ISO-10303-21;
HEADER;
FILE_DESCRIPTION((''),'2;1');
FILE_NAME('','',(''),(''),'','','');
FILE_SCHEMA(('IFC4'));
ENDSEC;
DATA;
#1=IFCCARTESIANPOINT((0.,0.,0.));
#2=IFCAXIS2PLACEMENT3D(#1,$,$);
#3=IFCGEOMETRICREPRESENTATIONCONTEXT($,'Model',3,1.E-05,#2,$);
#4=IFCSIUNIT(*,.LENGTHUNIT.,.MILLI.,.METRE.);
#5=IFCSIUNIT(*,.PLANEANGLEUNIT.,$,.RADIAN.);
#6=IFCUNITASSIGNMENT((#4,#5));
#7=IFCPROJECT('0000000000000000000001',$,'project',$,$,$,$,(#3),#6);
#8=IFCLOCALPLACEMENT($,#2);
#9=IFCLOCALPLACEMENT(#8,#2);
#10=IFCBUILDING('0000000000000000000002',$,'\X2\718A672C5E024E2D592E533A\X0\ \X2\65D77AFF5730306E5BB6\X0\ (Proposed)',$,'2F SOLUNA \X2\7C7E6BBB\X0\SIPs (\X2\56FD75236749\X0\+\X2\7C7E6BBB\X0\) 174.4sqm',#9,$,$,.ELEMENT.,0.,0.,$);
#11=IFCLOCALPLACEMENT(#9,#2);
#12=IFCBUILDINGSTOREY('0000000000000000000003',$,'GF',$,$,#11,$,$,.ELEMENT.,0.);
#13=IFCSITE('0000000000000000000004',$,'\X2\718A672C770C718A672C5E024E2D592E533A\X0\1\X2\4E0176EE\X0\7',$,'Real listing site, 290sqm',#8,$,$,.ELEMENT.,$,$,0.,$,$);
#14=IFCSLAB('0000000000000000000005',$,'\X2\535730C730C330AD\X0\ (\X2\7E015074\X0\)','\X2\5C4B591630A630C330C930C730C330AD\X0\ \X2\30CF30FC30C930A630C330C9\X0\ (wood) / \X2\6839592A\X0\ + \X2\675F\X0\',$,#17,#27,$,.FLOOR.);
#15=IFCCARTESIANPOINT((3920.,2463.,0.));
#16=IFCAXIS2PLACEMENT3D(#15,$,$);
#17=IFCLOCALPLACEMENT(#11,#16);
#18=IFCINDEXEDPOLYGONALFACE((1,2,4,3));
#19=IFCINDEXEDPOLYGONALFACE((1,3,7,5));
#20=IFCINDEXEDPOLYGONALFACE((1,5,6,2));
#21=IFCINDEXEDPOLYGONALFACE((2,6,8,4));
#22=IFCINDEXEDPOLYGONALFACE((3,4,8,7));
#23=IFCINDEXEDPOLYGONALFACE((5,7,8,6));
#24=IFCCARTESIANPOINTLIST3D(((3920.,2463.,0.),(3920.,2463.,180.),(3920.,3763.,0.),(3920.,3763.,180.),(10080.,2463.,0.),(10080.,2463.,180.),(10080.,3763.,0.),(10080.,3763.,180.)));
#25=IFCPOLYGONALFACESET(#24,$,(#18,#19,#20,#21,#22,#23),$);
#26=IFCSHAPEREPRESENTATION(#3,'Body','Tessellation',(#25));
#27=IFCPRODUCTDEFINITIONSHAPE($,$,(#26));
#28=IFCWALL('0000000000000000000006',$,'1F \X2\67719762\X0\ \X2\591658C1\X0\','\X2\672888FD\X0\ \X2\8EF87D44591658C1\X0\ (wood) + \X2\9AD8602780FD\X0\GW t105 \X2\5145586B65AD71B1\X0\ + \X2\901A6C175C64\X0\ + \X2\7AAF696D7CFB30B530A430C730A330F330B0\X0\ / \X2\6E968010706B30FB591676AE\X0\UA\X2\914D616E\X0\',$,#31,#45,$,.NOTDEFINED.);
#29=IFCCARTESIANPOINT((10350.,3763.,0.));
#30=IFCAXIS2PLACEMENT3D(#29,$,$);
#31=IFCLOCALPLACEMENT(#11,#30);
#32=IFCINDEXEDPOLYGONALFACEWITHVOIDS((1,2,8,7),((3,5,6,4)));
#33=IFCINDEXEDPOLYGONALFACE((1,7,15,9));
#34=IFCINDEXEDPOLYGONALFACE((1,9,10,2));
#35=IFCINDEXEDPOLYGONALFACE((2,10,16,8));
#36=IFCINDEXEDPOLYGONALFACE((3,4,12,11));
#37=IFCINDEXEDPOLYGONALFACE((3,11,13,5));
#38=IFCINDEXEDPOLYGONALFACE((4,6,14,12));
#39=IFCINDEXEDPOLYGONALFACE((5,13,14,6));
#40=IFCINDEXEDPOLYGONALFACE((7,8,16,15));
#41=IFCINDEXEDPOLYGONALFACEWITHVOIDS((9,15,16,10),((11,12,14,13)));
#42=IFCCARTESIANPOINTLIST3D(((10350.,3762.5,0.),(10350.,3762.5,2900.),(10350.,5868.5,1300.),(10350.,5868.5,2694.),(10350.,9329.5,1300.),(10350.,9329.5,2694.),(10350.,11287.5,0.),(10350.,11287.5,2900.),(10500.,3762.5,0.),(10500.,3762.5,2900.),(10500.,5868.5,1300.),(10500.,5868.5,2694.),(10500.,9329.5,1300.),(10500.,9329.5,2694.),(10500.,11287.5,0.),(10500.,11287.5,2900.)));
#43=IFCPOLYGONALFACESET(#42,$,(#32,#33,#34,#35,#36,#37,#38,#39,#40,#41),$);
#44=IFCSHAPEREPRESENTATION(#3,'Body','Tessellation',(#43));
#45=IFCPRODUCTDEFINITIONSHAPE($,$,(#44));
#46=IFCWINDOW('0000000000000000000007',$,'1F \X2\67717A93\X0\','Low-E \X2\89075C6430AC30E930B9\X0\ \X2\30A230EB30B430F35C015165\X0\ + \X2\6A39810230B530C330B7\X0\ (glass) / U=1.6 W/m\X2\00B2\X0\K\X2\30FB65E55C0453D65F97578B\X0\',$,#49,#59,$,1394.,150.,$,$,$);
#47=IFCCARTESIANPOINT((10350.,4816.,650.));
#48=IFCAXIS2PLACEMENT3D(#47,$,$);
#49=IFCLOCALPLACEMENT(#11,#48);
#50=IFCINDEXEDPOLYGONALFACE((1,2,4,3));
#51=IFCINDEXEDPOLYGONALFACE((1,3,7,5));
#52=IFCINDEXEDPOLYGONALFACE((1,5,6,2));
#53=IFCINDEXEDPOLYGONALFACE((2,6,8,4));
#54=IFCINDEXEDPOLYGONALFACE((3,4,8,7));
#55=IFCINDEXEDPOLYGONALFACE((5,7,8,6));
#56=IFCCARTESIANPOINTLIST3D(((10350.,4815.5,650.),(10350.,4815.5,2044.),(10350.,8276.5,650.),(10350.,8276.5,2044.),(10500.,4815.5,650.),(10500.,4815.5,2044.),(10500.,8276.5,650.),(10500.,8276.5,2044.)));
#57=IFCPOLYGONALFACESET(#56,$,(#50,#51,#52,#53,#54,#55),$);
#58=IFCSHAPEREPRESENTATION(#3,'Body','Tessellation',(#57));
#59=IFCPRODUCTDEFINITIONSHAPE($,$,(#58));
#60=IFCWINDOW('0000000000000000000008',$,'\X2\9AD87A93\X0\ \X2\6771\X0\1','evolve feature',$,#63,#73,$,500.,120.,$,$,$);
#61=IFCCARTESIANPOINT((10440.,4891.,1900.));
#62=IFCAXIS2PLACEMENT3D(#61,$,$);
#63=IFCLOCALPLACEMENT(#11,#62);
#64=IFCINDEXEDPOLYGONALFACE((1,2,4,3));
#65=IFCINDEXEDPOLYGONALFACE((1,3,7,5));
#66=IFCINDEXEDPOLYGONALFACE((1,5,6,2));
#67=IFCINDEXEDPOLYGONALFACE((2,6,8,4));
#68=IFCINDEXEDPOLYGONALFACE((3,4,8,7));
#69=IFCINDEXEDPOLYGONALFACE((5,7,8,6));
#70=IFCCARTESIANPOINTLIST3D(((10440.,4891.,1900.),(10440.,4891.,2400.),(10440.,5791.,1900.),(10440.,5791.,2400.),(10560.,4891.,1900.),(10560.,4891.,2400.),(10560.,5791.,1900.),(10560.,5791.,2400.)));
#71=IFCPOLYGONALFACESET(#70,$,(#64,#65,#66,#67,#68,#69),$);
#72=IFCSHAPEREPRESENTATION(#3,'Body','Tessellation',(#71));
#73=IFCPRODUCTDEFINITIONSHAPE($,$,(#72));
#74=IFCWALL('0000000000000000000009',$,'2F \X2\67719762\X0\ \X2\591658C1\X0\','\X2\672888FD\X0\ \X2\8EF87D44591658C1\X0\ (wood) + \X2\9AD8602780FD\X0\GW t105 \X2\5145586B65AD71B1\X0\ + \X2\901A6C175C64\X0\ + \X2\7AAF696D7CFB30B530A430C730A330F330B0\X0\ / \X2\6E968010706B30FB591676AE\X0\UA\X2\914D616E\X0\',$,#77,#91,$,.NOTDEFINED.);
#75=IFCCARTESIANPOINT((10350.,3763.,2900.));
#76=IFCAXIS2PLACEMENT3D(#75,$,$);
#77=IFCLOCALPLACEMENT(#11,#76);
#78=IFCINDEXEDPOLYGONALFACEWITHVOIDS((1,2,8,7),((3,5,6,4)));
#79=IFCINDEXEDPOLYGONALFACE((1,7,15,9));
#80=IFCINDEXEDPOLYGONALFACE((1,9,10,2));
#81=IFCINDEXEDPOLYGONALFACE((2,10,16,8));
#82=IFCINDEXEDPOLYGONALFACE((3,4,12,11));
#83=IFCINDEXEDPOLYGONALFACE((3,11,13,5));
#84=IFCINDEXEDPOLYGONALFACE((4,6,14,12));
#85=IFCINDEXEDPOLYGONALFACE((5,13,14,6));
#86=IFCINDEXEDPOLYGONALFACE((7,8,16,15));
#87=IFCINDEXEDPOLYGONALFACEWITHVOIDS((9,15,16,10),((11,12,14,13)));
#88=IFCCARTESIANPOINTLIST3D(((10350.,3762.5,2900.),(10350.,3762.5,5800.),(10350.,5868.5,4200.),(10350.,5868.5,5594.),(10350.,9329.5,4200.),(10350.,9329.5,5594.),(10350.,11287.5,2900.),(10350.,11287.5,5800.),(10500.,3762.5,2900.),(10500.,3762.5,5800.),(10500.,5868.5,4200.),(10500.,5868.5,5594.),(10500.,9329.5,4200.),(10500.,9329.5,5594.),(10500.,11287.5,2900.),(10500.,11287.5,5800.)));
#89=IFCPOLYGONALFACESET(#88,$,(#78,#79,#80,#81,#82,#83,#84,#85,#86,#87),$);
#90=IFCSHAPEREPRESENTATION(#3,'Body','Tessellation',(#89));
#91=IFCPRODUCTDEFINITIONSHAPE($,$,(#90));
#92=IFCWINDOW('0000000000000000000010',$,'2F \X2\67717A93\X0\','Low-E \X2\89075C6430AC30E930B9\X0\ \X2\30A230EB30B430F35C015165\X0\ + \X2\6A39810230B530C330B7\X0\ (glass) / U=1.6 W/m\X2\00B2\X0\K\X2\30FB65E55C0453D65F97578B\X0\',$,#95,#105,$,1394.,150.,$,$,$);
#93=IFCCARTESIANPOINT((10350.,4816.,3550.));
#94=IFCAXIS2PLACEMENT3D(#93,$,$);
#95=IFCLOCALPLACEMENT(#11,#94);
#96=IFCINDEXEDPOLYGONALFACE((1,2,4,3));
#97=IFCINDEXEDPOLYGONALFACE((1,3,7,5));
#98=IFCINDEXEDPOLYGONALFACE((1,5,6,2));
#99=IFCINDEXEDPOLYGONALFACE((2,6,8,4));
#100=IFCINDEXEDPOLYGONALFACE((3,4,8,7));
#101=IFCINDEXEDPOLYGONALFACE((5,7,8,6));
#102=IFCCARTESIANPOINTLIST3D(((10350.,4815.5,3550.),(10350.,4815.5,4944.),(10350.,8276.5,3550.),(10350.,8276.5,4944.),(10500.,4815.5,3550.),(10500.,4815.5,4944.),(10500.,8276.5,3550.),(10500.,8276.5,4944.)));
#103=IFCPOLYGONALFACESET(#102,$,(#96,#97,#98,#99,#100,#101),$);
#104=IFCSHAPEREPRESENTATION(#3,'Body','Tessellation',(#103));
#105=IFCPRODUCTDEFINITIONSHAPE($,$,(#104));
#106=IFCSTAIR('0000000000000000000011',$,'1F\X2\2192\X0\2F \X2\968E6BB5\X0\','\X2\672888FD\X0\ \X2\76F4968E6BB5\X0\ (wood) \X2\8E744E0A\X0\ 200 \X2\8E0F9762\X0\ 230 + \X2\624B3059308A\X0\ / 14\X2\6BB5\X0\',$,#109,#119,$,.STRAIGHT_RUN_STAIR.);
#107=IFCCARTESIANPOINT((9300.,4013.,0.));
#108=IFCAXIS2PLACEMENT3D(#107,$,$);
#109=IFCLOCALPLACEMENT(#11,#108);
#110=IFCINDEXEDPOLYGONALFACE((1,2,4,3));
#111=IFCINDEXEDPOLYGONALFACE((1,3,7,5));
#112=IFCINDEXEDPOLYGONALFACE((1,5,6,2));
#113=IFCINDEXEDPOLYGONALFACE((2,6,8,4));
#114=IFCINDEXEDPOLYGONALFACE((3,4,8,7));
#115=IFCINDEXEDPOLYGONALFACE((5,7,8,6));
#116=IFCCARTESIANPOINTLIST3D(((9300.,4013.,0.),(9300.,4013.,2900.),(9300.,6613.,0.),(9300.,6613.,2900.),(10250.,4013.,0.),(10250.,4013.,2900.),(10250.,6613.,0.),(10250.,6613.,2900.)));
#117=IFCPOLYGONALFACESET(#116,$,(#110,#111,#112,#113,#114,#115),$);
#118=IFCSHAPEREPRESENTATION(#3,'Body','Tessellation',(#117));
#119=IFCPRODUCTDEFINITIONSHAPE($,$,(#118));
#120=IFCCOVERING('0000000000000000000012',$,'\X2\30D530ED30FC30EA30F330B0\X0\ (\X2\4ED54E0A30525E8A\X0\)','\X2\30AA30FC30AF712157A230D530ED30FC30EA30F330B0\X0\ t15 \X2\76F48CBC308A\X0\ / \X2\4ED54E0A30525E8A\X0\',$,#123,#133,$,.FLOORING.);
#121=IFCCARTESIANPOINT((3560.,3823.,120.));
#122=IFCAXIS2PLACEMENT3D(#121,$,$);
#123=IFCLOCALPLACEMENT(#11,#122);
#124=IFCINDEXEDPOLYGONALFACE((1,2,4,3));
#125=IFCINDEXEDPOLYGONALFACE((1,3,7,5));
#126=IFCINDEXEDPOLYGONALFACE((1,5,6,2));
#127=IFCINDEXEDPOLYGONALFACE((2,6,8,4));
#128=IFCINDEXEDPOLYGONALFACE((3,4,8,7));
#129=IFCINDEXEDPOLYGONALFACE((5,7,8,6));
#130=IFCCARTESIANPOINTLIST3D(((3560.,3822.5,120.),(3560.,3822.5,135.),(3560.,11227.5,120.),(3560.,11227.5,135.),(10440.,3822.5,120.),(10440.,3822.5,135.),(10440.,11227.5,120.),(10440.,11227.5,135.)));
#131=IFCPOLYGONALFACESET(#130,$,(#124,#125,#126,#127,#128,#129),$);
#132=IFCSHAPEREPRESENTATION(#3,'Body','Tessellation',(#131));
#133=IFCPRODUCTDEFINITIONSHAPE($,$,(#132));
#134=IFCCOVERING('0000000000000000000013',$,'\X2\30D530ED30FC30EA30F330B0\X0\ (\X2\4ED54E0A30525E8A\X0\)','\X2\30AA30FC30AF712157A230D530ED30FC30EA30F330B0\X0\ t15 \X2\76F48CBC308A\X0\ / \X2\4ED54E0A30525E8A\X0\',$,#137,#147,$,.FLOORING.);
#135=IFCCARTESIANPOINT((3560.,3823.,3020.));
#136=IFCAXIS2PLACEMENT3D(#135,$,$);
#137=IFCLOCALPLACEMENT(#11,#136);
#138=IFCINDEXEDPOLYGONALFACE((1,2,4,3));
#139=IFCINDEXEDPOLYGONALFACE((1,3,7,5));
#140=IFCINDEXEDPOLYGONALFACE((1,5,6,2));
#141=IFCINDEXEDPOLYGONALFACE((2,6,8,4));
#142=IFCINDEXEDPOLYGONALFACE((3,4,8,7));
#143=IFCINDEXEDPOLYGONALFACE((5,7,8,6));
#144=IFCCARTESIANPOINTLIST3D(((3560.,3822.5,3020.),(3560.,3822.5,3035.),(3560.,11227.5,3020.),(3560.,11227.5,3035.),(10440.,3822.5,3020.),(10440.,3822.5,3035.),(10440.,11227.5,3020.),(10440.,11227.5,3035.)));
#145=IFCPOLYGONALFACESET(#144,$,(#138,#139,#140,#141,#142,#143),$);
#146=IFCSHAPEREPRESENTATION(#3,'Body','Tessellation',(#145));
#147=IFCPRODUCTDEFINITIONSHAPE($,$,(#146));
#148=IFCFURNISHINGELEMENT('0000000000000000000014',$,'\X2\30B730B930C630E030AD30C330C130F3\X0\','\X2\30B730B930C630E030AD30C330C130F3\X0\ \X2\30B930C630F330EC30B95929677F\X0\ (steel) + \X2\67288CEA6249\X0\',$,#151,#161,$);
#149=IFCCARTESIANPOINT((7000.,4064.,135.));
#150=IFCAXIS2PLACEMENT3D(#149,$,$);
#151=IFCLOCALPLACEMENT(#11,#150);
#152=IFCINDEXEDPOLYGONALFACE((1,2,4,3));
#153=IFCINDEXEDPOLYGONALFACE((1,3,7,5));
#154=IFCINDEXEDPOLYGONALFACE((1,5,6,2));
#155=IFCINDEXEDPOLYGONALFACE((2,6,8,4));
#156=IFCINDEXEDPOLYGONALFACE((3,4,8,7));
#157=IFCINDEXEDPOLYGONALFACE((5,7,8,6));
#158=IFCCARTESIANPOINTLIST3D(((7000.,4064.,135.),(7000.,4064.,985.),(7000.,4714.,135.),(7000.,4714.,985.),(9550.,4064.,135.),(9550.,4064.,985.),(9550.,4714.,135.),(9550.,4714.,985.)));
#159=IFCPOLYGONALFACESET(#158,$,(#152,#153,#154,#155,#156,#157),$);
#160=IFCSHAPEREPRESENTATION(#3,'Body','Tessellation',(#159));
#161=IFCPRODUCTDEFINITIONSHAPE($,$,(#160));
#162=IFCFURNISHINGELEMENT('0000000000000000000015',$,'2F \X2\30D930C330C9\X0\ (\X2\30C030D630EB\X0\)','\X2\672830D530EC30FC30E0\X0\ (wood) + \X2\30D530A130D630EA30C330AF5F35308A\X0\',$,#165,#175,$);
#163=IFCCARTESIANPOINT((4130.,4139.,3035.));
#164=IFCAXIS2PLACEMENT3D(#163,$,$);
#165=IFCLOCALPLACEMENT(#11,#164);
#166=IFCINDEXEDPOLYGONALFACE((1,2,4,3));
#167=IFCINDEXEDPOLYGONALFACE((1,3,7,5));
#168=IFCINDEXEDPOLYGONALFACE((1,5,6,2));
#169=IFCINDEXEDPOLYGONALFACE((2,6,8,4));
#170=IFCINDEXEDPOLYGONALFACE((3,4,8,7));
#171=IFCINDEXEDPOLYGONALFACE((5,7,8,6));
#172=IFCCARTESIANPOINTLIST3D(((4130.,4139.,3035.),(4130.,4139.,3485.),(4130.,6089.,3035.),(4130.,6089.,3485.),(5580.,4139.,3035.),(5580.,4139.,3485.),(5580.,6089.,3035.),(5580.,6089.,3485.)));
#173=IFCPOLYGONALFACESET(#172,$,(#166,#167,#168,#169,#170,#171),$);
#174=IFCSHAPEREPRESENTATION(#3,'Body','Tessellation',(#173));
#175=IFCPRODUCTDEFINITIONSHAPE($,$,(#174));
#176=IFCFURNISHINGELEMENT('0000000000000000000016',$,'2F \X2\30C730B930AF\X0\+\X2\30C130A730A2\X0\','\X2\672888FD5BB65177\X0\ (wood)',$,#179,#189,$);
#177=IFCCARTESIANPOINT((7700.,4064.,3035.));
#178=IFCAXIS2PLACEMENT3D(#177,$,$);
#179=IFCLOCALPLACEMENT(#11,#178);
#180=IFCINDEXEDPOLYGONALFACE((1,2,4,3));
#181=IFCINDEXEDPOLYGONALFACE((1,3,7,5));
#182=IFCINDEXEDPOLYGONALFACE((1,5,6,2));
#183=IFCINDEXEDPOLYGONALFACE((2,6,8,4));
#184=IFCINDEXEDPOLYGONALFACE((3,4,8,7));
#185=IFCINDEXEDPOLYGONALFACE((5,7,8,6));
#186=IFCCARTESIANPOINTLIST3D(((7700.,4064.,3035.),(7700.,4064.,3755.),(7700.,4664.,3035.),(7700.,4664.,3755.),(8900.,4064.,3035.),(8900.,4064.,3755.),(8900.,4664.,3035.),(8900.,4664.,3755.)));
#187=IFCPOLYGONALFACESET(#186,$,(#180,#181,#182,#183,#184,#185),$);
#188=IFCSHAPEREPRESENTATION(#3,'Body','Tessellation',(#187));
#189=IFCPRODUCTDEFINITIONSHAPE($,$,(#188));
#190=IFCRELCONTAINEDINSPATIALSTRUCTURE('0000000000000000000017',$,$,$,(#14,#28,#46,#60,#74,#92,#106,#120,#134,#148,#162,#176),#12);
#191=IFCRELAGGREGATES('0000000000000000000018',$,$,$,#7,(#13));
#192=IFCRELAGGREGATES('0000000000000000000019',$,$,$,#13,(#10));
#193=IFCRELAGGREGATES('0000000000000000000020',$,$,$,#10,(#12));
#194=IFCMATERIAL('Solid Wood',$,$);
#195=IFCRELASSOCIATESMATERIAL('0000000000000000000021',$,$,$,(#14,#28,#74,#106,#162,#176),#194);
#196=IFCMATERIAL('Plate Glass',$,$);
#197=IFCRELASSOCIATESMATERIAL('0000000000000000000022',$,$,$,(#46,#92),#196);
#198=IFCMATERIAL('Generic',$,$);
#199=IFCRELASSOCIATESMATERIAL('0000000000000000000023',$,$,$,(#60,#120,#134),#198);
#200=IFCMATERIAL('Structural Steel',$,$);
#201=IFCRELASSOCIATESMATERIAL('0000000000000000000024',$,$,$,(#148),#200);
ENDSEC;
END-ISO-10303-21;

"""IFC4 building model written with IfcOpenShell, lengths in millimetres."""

from ifc_helpers import new_model, si_unit, frame, frame_2d, origin, place, context, project, spatial, rectangle, extrude, material, element, fill, save


model = new_model("IFC4")

# Units and contexts
model_context = context("Model", 3, precision=1e-05, world=origin())
ifc_project = project(units=[si_unit("LENGTHUNIT", "METRE", prefix="MILLI"), si_unit("PLANEANGLEUNIT", "RADIAN")], contexts=[model_context])

# Site, building, storey
site_placement = place(None, origin())
site = spatial("IfcSite", under=ifc_project, at=site_placement, Name="熊本県熊本市中央区1丁目7", ObjectType="Real listing site, 290sqm", CompositionType="ELEMENT", RefElevation=0.0)
building_placement = place(site_placement, origin())
building = spatial("IfcBuilding", under=site, at=building_placement, Name="熊本市中央区 旗竿地の家 (Proposed)", ObjectType="2F SOLUNA 籾殻SIPs (国産杉+籾殻) 174.4sqm", CompositionType="ELEMENT", ElevationOfRefHeight=0.0, ElevationOfTerrain=0.0)
storey_placement = place(building_placement, origin())
storey = spatial("IfcBuildingStorey", under=building, at=storey_placement, Name="GF", CompositionType="ELEMENT", Elevation=0.0)

# Slab
ifc_material_1 = material(Name="Solid Wood")
slab_placement = place(storey_placement, frame((3920.0, 2463.0, 0.0)))
element("IfcSlab", 1, at=slab_placement, inside=storey, material=ifc_material_1, Name="南デッキ (縁側)", Description="屋外ウッドデッキ ハードウッド (wood) / 根太 + 束", PredefinedType="FLOOR", context=model_context, shape_type="SweptSolid", body=[
    extrude(rectangle(XDim=6160.0, YDim=1300.0, at=frame_2d((3080.0, 650.0))), frame((3920.0, 2463.0, 0.0)), (0.0, 0.0, 1.0), 180.0),
])

# Wall, openings, windows
wall_1_placement = place(storey_placement, frame((10350.0, 3763.0, 0.0)))
wall_1 = element("IfcWall", 2, at=wall_1_placement, inside=storey, material=ifc_material_1, Name="1F 東面 外壁", Description="木製 軸組外壁 (wood) + 高性能GW t105 充填断熱 + 通気層 + 窯業系サイディング / 準耐火・外皮UA配慮", PredefinedType="NOTDEFINED", context=model_context, shape_type="SweptSolid", body=[
    extrude(rectangle(XDim=150.0, YDim=7525.0, at=frame_2d((75.0, 3762.0))), frame((10350.0, 3763.0, 0.0)), (0.0, 0.0, 1.0), 2900.0),
])
opening_1_placement = place(storey_placement, frame((10350.0, 4816.0, 650.0)))
opening_1 = element("IfcOpeningElement", 3, at=opening_1_placement, cuts=wall_1, PredefinedType="NOTDEFINED", context=model_context, shape_type="SweptSolid", body=[
    extrude(rectangle(XDim=150.0, YDim=3461.0, at=frame_2d((75.0, 1730.0))), frame((10350.0, 4816.0, 650.0)), (0.0, 0.0, 1.0), 1394.0),
])
opening_2_placement = place(storey_placement, frame((10440.0, 4891.0, 1900.0)))
opening_2 = element("IfcOpeningElement", 4, at=opening_2_placement, cuts=wall_1, PredefinedType="NOTDEFINED", context=model_context, shape_type="SweptSolid", body=[
    extrude(rectangle(XDim=120.0, YDim=900.0, at=frame_2d((60.0, 450.0))), frame((10440.0, 4891.0, 1900.0)), (0.0, 0.0, 1.0), 500.0),
])
ifc_material_2 = material(Name="Plate Glass")
window_1_placement = place(storey_placement, frame((10350.0, 4816.0, 650.0)))
window_1 = element("IfcWindow", 5, at=window_1_placement, inside=storey, material=ifc_material_2, Name="1F 東窓", Description="Low-E 複層ガラス アルゴン封入 + 樹脂サッシ (glass) / U=1.6 W/m²K・日射取得型", OverallHeight=1394.0, OverallWidth=150.0, context=model_context, shape_type="SweptSolid", body=[
    extrude(rectangle(XDim=150.0, YDim=3461.0, at=frame_2d((75.0, 1730.0))), frame((10350.0, 4816.0, 650.0)), (0.0, 0.0, 1.0), 1394.0),
])
fill(opening_1, window_1)
ifc_material_3 = material(Name="Generic")
window_2_placement = place(storey_placement, frame((10440.0, 4891.0, 1900.0)))
window_2 = element("IfcWindow", 6, at=window_2_placement, inside=storey, material=ifc_material_3, Name="高窓 東1", Description="evolve feature", OverallHeight=500.0, OverallWidth=120.0, context=model_context, shape_type="SweptSolid", body=[
    extrude(rectangle(XDim=120.0, YDim=900.0, at=frame_2d((60.0, 450.0))), frame((10440.0, 4891.0, 1900.0)), (0.0, 0.0, 1.0), 500.0),
])
fill(opening_2, window_2)

# Wall, opening, window
wall_2_placement = place(storey_placement, frame((10350.0, 3763.0, 2900.0)))
wall_2 = element("IfcWall", 7, at=wall_2_placement, inside=storey, material=ifc_material_1, Name="2F 東面 外壁", Description="木製 軸組外壁 (wood) + 高性能GW t105 充填断熱 + 通気層 + 窯業系サイディング / 準耐火・外皮UA配慮", PredefinedType="NOTDEFINED", context=model_context, shape_type="SweptSolid", body=[
    extrude(rectangle(XDim=150.0, YDim=7525.0, at=frame_2d((75.0, 3762.0))), frame((10350.0, 3763.0, 2900.0)), (0.0, 0.0, 1.0), 2900.0),
])
opening_3_placement = place(storey_placement, frame((10350.0, 4816.0, 3550.0)))
opening_3 = element("IfcOpeningElement", 8, at=opening_3_placement, cuts=wall_2, PredefinedType="NOTDEFINED", context=model_context, shape_type="SweptSolid", body=[
    extrude(rectangle(XDim=150.0, YDim=3461.0, at=frame_2d((75.0, 1730.0))), frame((10350.0, 4816.0, 3550.0)), (0.0, 0.0, 1.0), 1394.0),
])
window_3_placement = place(storey_placement, frame((10350.0, 4816.0, 3550.0)))
window_3 = element("IfcWindow", 9, at=window_3_placement, inside=storey, material=ifc_material_2, Name="2F 東窓", Description="Low-E 複層ガラス アルゴン封入 + 樹脂サッシ (glass) / U=1.6 W/m²K・日射取得型", OverallHeight=1394.0, OverallWidth=150.0, context=model_context, shape_type="SweptSolid", body=[
    extrude(rectangle(XDim=150.0, YDim=3461.0, at=frame_2d((75.0, 1730.0))), frame((10350.0, 4816.0, 3550.0)), (0.0, 0.0, 1.0), 1394.0),
])
fill(opening_3, window_3)

# Stair
stair_placement = place(storey_placement, frame((9300.0, 4013.0, 0.0)))
element("IfcStair", 10, at=stair_placement, inside=storey, material=ifc_material_1, Name="1F→2F 階段", Description="木製 直階段 (wood) 蹴上 200 踏面 230 + 手すり / 14段", PredefinedType="STRAIGHT_RUN_STAIR", context=model_context, shape_type="SweptSolid", body=[
    extrude(rectangle(XDim=950.0, YDim=2600.0, at=frame_2d((475.0, 1300.0))), frame((9300.0, 4013.0, 0.0)), (0.0, 0.0, 1.0), 2900.0),
])

# Coverings
covering_1_placement = place(storey_placement, frame((3560.0, 3823.0, 120.0)))
element("IfcCovering", 11, at=covering_1_placement, inside=storey, material=ifc_material_3, Name="フローリング (仕上げ床)", Description="オーク無垢フローリング t15 直貼り / 仕上げ床", PredefinedType="FLOORING", context=model_context, shape_type="SweptSolid", body=[
    extrude(rectangle(XDim=6880.0, YDim=7405.0, at=frame_2d((3440.0, 3702.0))), frame((3560.0, 3823.0, 120.0)), (0.0, 0.0, 1.0), 15.0),
])
covering_2_placement = place(storey_placement, frame((3560.0, 3823.0, 3020.0)))
element("IfcCovering", 12, at=covering_2_placement, inside=storey, material=ifc_material_3, Name="フローリング (仕上げ床)", Description="オーク無垢フローリング t15 直貼り / 仕上げ床", PredefinedType="FLOORING", context=model_context, shape_type="SweptSolid", body=[
    extrude(rectangle(XDim=6880.0, YDim=7405.0, at=frame_2d((3440.0, 3702.0))), frame((3560.0, 3823.0, 3020.0)), (0.0, 0.0, 1.0), 15.0),
])

# Furnishing elements
ifc_material_4 = material(Name="Structural Steel")
furnishing_1_placement = place(storey_placement, frame((7000.0, 4064.0, 135.0)))
element("IfcFurnishingElement", 13, at=furnishing_1_placement, inside=storey, material=ifc_material_4, Name="システムキッチン", Description="システムキッチン ステンレス天板 (steel) + 木質扉", context=model_context, shape_type="SweptSolid", body=[
    extrude(rectangle(XDim=2550.0, YDim=650.0, at=frame_2d((1275.0, 325.0))), frame((7000.0, 4064.0, 135.0)), (0.0, 0.0, 1.0), 850.0),
])
furnishing_2_placement = place(storey_placement, frame((4130.0, 4139.0, 3035.0)))
element("IfcFurnishingElement", 14, at=furnishing_2_placement, inside=storey, material=ifc_material_1, Name="2F ベッド (ダブル)", Description="木フレーム (wood) + ファブリック張り", context=model_context, shape_type="SweptSolid", body=[
    extrude(rectangle(XDim=1450.0, YDim=1950.0, at=frame_2d((725.0, 975.0))), frame((4130.0, 4139.0, 3035.0)), (0.0, 0.0, 1.0), 450.0),
])
furnishing_3_placement = place(storey_placement, frame((7700.0, 4064.0, 3035.0)))
element("IfcFurnishingElement", 15, at=furnishing_3_placement, inside=storey, material=ifc_material_1, Name="2F デスク+チェア", Description="木製家具 (wood)", context=model_context, shape_type="SweptSolid", body=[
    extrude(rectangle(XDim=1200.0, YDim=600.0, at=frame_2d((600.0, 300.0))), frame((7700.0, 4064.0, 3035.0)), (0.0, 0.0, 1.0), 720.0),
])

save(model, "model.ifc")
